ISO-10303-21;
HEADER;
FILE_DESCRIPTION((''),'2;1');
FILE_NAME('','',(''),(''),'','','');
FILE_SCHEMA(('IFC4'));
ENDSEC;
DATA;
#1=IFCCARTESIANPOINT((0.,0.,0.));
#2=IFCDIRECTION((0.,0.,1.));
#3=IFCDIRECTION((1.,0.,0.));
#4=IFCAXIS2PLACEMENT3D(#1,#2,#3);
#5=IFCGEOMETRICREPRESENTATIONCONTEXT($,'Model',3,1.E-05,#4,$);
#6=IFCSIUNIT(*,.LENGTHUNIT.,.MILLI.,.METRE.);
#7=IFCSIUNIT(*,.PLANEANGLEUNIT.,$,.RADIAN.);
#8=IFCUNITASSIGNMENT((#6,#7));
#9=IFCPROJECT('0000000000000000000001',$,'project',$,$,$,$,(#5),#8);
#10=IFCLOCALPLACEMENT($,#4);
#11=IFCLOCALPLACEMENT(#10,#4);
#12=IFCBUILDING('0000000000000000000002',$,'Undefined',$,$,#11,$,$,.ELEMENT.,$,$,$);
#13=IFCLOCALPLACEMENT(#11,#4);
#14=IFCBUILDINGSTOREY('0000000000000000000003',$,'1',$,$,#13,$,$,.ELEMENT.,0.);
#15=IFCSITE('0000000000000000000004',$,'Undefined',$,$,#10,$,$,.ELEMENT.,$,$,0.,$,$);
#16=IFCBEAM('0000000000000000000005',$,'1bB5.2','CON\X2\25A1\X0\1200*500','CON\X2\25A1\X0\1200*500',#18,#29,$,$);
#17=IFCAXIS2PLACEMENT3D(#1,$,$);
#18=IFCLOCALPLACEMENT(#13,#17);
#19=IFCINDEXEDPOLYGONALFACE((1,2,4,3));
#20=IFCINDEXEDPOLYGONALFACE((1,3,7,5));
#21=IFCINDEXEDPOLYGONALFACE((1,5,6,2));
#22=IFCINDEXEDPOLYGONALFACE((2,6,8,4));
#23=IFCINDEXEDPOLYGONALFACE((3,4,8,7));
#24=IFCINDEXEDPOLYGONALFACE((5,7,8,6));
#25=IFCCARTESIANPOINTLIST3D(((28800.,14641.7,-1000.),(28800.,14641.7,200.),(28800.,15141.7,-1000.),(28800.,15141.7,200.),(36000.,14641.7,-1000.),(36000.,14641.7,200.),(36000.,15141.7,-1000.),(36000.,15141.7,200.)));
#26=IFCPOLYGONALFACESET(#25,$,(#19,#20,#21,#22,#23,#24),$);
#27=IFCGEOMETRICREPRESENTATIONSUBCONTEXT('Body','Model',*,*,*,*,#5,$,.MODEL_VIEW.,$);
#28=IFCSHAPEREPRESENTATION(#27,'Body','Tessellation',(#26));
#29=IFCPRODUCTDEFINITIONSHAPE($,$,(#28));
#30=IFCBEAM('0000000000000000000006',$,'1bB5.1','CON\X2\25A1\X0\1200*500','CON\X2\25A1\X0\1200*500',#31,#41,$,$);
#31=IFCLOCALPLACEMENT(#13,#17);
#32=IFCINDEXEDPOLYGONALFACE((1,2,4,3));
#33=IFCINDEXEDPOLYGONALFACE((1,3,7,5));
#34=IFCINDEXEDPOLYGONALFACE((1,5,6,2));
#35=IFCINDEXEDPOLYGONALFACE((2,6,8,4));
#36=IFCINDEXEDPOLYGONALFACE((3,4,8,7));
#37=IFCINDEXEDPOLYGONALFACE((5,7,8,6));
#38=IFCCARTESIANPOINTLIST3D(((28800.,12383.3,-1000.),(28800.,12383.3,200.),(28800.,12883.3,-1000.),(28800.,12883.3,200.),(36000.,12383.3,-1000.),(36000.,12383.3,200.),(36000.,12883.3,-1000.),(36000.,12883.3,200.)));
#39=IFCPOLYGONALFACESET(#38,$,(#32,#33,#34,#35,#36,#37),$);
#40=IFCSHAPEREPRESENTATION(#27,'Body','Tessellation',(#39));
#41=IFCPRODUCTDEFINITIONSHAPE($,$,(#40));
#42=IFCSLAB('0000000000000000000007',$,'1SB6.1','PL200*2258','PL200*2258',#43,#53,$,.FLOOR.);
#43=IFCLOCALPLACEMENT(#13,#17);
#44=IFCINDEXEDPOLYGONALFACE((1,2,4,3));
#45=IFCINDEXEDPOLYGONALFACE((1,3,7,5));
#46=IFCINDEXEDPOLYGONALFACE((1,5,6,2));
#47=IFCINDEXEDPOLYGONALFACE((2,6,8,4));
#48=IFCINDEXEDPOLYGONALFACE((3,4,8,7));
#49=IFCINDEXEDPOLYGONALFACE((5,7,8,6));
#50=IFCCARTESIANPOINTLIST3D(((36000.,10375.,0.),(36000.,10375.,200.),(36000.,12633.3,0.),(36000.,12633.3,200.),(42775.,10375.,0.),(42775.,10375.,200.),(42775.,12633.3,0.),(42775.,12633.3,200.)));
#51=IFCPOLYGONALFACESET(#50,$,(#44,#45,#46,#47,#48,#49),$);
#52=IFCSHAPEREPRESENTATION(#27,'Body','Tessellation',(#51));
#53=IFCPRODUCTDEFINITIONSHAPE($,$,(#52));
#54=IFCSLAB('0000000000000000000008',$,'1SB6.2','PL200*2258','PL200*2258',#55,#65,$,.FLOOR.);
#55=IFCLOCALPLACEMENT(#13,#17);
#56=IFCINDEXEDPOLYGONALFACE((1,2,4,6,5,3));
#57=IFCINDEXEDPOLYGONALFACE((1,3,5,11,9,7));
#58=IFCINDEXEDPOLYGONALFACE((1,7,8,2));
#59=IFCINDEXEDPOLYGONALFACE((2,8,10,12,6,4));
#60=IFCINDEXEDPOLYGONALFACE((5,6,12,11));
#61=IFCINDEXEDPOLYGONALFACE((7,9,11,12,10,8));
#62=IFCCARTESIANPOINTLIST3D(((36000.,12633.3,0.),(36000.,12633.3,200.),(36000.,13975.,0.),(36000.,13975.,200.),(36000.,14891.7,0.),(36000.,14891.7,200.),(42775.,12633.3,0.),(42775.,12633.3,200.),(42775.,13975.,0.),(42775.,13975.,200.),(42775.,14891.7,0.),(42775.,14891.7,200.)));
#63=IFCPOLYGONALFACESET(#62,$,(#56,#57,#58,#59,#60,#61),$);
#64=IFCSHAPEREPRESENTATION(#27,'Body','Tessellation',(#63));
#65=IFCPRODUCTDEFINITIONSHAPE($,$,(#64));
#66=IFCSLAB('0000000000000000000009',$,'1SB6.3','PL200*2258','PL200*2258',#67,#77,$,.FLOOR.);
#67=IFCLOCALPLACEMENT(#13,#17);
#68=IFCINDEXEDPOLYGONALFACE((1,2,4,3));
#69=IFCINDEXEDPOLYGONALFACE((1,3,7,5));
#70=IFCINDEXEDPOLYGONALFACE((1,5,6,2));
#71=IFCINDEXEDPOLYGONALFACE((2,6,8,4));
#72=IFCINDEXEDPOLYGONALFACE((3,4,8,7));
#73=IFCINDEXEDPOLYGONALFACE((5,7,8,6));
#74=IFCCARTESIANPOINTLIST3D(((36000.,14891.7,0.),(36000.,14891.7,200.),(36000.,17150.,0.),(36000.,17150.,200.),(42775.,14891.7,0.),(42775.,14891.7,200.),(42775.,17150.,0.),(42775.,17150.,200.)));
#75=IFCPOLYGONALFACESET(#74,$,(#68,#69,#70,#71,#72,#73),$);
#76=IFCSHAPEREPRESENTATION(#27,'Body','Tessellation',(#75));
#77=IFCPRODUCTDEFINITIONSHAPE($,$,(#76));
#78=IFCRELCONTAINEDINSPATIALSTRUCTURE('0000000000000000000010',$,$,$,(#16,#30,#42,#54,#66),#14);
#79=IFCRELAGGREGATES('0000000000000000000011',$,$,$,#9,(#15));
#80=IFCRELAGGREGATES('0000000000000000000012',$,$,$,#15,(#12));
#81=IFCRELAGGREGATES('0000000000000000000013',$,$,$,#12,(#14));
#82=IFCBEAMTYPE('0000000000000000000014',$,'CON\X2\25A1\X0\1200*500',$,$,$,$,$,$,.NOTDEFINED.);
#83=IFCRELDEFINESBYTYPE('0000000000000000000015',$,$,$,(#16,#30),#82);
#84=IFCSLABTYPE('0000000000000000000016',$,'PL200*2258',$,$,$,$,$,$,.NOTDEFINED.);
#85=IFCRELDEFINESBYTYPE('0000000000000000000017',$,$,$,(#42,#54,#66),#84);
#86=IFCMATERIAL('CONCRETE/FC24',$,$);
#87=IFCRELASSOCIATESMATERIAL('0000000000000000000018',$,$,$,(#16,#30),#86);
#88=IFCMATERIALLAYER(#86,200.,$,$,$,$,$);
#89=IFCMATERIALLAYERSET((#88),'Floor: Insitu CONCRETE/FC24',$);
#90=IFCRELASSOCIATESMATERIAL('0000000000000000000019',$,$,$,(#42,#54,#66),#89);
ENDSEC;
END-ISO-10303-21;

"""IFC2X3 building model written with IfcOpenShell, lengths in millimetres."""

from ifc_helpers import new_model, si_unit, frame, origin_with_axes, origin_2d_with_axis, place, context, subcontext, project, spatial, polyline, rectangle, outline, extrude, material, layer, layer_set, layer_usage, type_object, element, save


model = new_model("IFC2X3")

# Units and contexts
model_context = context("Model", 3, precision=1e-05, world=origin_with_axes())
body_context = subcontext(model_context, "Body", "Model", "MODEL_VIEW")
ifc_project = project(units=[si_unit("LENGTHUNIT", "METRE", prefix="MILLI"), si_unit("PLANEANGLEUNIT", "RADIAN")], contexts=[model_context])

# Site, building, storey
site_placement = place(None, origin_with_axes())
site = spatial("IfcSite", under=ifc_project, at=site_placement, Name="Undefined", CompositionType="ELEMENT", RefElevation=0.0)
building_placement = place(site_placement, origin_with_axes())
building = spatial("IfcBuilding", under=site, at=building_placement, Name="Undefined", CompositionType="ELEMENT")
storey_placement = place(building_placement, origin_with_axes())
storey = spatial("IfcBuildingStorey", under=building, at=storey_placement, Name="1", CompositionType="ELEMENT", Elevation=0.0)

# Shared definitions
ifc_material_1 = material(Name="CONCRETE/FC24")

# Beams
beam_type_1 = type_object("IfcBeamType", Name="CON□1200*500", PredefinedType="NOTDEFINED")
for number, where, z_axis, x_axis, name in (
    (1, (28800.0, 14891.7, -400.0), (0.0, 0.0, 1.0), (1.0, 0.0, 0.0), "1bB5.2"),
    (2, (28800.0, 12633.3, -400.0), (0.0, 0.0, 1.0), (1.0, 0.0, 0.0), "1bB5.1"),
):
    element("IfcBeam", number, at=place(storey_placement, frame(where, z_axis=z_axis, x_axis=x_axis)), inside=storey, type_object=beam_type_1, material=ifc_material_1, Name=name, Description="CON□1200*500", ObjectType="CON□1200*500", context=body_context, shape_type="SweptSolid", body=[
        extrude(rectangle(XDim=500.0, YDim=1200.0, at=origin_2d_with_axis()), frame((7200.0, 0.0, 0.0), z_axis=(-1.0, 0.0, 0.0), x_axis=(0.0, -1.0, 0.0)), (0.0, 0.0, 1.0), 7200.0),
    ])

# Slabs
ifc_layer = layer(ifc_material_1, 200.0)
ifc_layer_set = layer_set([ifc_layer], Name="Floor: Insitu CONCRETE/FC24")
ifc_layer_usage_1 = layer_usage(ifc_layer_set, "AXIS3", "POSITIVE", -100.0)
slab_type = type_object("IfcSlabType", Name="PL200*2258", PredefinedType="NOTDEFINED")
slab_1_placement = place(storey_placement, frame((36000.0, 10375.0, 100.0), z_axis=(0.0, 0.0, 1.0), x_axis=(1.0, 0.0, 0.0)))
element("IfcSlab", 3, at=slab_1_placement, inside=storey, type_object=slab_type, material=ifc_layer_usage_1, Name="1SB6.1", Description="PL200*2258", ObjectType="PL200*2258", PredefinedType="FLOOR", context=body_context, shape_type="SweptSolid", body=[
    extrude(outline(polyline([(0.0, 0.0), (6775.0, 0.0), (6775.0, 2258.3), (0.0, 2258.3), (0.0, 0.0)])), frame((0.0, 0.0, -100.0), z_axis=(0.0, 0.0, 1.0), x_axis=(1.0, 0.0, 0.0)), (0.0, 0.0, 1.0), 200.0),
])
ifc_layer_usage_2 = layer_usage(ifc_layer_set, "AXIS3", "POSITIVE", -100.0)
slab_2_placement = place(storey_placement, frame((36000.0, 12633.3, 100.0), z_axis=(0.0, 0.0, 1.0), x_axis=(1.0, 0.0, 0.0)))
element("IfcSlab", 4, at=slab_2_placement, inside=storey, type_object=slab_type, material=ifc_layer_usage_2, Name="1SB6.2", Description="PL200*2258", ObjectType="PL200*2258", PredefinedType="FLOOR", context=body_context, shape_type="SweptSolid", body=[
    extrude(outline(polyline([(0.0, 0.0), (6775.0, 0.0), (6775.0, 1341.7), (6775.0, 2258.4), (0.0, 2258.4), (0.0, 1341.7), (0.0, 0.0)])), frame((0.0, 0.0, -100.0), z_axis=(0.0, 0.0, 1.0), x_axis=(1.0, 0.0, 0.0)), (0.0, 0.0, 1.0), 200.0),
])
ifc_layer_usage_3 = layer_usage(ifc_layer_set, "AXIS3", "POSITIVE", -100.0)
slab_3_placement = place(storey_placement, frame((36000.0, 14891.7, 100.0), z_axis=(0.0, 0.0, 1.0), x_axis=(1.0, 0.0, 0.0)))
element("IfcSlab", 5, at=slab_3_placement, inside=storey, type_object=slab_type, material=ifc_layer_usage_3, Name="1SB6.3", Description="PL200*2258", ObjectType="PL200*2258", PredefinedType="FLOOR", context=body_context, shape_type="SweptSolid", body=[
    extrude(outline(polyline([(0.0, 0.0), (6775.0, 0.0), (6775.0, 2258.3), (0.0, 2258.3), (0.0, 0.0)])), frame((0.0, 0.0, -100.0), z_axis=(0.0, 0.0, 1.0), x_axis=(1.0, 0.0, 0.0)), (0.0, 0.0, 1.0), 200.0),
])

save(model, "model.ifc")
